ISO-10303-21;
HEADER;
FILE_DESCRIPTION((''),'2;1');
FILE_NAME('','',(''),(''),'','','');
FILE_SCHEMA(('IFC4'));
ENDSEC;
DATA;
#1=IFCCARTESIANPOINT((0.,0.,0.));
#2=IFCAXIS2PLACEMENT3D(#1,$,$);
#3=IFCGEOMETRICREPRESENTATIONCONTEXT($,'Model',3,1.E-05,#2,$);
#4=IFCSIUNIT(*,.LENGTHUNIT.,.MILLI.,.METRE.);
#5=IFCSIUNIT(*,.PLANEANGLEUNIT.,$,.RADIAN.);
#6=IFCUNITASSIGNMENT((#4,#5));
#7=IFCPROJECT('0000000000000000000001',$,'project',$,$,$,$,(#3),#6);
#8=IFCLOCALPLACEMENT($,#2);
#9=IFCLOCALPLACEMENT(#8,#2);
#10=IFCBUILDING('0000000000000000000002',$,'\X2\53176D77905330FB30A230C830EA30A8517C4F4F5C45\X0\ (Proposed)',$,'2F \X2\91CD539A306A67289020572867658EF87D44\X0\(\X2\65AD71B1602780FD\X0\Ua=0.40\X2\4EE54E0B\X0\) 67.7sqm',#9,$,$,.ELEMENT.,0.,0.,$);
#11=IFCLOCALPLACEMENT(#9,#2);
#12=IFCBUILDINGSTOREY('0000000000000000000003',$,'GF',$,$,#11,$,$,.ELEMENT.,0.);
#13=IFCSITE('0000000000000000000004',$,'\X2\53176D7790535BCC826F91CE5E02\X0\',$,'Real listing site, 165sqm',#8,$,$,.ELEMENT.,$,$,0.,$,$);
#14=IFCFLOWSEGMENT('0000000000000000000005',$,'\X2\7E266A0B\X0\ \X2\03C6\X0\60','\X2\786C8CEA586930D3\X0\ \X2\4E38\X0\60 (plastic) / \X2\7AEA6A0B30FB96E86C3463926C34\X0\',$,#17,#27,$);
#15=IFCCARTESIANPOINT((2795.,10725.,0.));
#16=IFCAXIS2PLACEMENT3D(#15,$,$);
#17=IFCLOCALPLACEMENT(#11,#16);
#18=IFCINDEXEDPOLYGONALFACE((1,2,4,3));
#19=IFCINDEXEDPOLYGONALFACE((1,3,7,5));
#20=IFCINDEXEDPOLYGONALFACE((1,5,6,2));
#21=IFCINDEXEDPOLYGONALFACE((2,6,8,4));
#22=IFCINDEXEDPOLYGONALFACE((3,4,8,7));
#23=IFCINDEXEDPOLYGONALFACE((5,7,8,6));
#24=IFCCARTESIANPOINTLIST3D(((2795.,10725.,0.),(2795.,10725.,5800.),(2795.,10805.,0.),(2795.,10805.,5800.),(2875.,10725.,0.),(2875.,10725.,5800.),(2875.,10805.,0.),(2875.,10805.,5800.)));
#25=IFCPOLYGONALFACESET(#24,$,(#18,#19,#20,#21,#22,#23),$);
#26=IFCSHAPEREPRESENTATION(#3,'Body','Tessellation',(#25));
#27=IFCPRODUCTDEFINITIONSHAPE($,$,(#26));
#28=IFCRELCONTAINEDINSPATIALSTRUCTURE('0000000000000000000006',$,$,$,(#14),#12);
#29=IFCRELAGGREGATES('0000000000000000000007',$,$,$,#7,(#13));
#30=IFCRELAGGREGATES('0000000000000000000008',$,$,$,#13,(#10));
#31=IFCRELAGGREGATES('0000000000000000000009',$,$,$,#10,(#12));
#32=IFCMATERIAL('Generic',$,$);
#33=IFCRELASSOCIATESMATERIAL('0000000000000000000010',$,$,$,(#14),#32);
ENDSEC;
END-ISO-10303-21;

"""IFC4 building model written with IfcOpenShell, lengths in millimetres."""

from ifc_helpers import new_model, si_unit, frame, frame_2d, origin, place, context, project, spatial, rectangle, extrude, material, element, save


model = new_model("IFC4")

# Units and contexts
model_context = context("Model", 3, precision=1e-05, world=origin())
ifc_project = project(units=[si_unit("LENGTHUNIT", "METRE", prefix="MILLI"), si_unit("PLANEANGLEUNIT", "RADIAN")], contexts=[model_context])

# Site, building, storey
site_placement = place(None, origin())
site = spatial("IfcSite", under=ifc_project, at=site_placement, Name="北海道富良野市", ObjectType="Real listing site, 165sqm", CompositionType="ELEMENT", RefElevation=0.0)
building_placement = place(site_placement, origin())
building = spatial("IfcBuilding", under=site, at=building_placement, Name="北海道・アトリエ兼住居 (Proposed)", ObjectType="2F 重厚な木造在来軸組(断熱性能Ua=0.40以下) 67.7sqm", CompositionType="ELEMENT", ElevationOfRefHeight=0.0, ElevationOfTerrain=0.0)
storey_placement = place(building_placement, origin())
storey = spatial("IfcBuildingStorey", under=building, at=storey_placement, Name="GF", CompositionType="ELEMENT", Elevation=0.0)

# Shared definitions
ifc_material_1 = material(Name="Generic")

# Flow segment
flow_segment_placement = place(storey_placement, frame((2795.0, 10725.0, 0.0)))
element("IfcFlowSegment", 1, at=flow_segment_placement, inside=storey, material=ifc_material_1, Name="縦樋 φ60", Description="硬質塩ビ 丸60 (plastic) / 竪樋・雨水排水", context=model_context, shape_type="SweptSolid", body=[
    extrude(rectangle(XDim=80.0, YDim=80.0, at=frame_2d((40.0, 40.0))), frame((2795.0, 10725.0, 0.0)), (0.0, 0.0, 1.0), 5800.0),
])

save(model, "model.ifc")
